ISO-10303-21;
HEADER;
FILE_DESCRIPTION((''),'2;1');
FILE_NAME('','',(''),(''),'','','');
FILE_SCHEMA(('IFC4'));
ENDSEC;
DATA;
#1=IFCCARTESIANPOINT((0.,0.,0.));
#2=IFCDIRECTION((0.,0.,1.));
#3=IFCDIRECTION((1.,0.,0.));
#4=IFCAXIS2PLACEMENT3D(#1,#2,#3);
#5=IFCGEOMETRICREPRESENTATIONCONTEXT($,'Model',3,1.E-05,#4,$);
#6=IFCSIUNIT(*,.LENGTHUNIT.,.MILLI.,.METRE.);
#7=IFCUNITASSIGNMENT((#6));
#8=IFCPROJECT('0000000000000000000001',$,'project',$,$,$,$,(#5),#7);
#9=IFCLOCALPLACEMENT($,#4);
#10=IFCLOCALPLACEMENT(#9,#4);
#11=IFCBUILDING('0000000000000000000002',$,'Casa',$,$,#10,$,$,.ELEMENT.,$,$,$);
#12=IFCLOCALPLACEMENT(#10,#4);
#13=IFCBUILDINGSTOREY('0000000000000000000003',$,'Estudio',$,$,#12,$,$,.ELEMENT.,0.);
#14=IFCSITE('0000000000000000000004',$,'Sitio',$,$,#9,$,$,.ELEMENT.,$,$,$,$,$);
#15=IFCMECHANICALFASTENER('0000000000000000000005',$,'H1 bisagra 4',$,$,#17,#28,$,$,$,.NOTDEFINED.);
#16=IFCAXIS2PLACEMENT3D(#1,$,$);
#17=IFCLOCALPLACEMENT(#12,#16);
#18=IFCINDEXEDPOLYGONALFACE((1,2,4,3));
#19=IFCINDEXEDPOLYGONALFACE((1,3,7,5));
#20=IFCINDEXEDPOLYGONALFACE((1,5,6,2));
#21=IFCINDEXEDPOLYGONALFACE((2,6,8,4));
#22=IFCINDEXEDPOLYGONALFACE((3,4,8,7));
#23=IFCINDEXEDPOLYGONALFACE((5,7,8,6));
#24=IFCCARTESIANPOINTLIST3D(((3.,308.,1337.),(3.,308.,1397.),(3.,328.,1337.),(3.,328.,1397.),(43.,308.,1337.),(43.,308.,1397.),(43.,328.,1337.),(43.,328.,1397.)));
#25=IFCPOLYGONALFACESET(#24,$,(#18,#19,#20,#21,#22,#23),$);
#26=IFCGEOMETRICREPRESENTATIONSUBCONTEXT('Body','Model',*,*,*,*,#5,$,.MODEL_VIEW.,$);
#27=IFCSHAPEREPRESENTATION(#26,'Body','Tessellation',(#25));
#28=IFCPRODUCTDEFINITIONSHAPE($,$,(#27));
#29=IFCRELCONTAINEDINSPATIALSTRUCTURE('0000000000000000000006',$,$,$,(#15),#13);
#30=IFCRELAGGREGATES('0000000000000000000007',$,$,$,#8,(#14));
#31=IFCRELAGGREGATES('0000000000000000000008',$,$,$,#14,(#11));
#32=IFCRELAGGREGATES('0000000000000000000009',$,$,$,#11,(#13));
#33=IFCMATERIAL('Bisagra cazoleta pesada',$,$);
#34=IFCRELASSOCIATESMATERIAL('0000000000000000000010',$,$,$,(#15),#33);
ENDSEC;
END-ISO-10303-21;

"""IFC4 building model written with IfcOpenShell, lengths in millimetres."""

from ifc_helpers import new_model, si_unit, frame, frame_2d, origin_with_axes, place, context, subcontext, project, spatial, rectangle, extrude, material, element, save


model = new_model("IFC4")

# Units and contexts
model_context = context("Model", 3, precision=1e-05, world=origin_with_axes())
body_context = subcontext(model_context, "Body", "Model", "MODEL_VIEW")
ifc_project = project(units=[si_unit("LENGTHUNIT", "METRE", prefix="MILLI")], contexts=[model_context])

# Site, building, storey
site_placement = place(None, origin_with_axes())
site = spatial("IfcSite", under=ifc_project, at=site_placement, Name="Sitio", CompositionType="ELEMENT")
building_placement = place(site_placement, origin_with_axes())
building = spatial("IfcBuilding", under=site, at=building_placement, Name="Casa", CompositionType="ELEMENT")
storey_placement = place(building_placement, origin_with_axes())
storey = spatial("IfcBuildingStorey", under=building, at=storey_placement, Name="Estudio", CompositionType="ELEMENT", Elevation=0.0)

# Mechanical fastener
ifc_material_1 = material(Name="Bisagra cazoleta pesada")
for number, where, z_axis, x_axis, name in (
    (1, (3.0, 308.0, 1337.0), (0.0, 0.0, 1.0), (1.0, 0.0, 0.0), "H1 bisagra 4"),
):
    element("IfcMechanicalFastener", number, at=place(storey_placement, frame(where, z_axis=z_axis, x_axis=x_axis)), inside=storey, material=ifc_material_1, Name=name, PredefinedType="NOTDEFINED", context=body_context, shape_type="SweptSolid", body=[
        extrude(rectangle(XDim=40.0, YDim=20.0, at=frame_2d((20.0, 10.0))), origin_with_axes(), (0.0, 0.0, 1.0), 60.0),
    ])

save(model, "model.ifc")
